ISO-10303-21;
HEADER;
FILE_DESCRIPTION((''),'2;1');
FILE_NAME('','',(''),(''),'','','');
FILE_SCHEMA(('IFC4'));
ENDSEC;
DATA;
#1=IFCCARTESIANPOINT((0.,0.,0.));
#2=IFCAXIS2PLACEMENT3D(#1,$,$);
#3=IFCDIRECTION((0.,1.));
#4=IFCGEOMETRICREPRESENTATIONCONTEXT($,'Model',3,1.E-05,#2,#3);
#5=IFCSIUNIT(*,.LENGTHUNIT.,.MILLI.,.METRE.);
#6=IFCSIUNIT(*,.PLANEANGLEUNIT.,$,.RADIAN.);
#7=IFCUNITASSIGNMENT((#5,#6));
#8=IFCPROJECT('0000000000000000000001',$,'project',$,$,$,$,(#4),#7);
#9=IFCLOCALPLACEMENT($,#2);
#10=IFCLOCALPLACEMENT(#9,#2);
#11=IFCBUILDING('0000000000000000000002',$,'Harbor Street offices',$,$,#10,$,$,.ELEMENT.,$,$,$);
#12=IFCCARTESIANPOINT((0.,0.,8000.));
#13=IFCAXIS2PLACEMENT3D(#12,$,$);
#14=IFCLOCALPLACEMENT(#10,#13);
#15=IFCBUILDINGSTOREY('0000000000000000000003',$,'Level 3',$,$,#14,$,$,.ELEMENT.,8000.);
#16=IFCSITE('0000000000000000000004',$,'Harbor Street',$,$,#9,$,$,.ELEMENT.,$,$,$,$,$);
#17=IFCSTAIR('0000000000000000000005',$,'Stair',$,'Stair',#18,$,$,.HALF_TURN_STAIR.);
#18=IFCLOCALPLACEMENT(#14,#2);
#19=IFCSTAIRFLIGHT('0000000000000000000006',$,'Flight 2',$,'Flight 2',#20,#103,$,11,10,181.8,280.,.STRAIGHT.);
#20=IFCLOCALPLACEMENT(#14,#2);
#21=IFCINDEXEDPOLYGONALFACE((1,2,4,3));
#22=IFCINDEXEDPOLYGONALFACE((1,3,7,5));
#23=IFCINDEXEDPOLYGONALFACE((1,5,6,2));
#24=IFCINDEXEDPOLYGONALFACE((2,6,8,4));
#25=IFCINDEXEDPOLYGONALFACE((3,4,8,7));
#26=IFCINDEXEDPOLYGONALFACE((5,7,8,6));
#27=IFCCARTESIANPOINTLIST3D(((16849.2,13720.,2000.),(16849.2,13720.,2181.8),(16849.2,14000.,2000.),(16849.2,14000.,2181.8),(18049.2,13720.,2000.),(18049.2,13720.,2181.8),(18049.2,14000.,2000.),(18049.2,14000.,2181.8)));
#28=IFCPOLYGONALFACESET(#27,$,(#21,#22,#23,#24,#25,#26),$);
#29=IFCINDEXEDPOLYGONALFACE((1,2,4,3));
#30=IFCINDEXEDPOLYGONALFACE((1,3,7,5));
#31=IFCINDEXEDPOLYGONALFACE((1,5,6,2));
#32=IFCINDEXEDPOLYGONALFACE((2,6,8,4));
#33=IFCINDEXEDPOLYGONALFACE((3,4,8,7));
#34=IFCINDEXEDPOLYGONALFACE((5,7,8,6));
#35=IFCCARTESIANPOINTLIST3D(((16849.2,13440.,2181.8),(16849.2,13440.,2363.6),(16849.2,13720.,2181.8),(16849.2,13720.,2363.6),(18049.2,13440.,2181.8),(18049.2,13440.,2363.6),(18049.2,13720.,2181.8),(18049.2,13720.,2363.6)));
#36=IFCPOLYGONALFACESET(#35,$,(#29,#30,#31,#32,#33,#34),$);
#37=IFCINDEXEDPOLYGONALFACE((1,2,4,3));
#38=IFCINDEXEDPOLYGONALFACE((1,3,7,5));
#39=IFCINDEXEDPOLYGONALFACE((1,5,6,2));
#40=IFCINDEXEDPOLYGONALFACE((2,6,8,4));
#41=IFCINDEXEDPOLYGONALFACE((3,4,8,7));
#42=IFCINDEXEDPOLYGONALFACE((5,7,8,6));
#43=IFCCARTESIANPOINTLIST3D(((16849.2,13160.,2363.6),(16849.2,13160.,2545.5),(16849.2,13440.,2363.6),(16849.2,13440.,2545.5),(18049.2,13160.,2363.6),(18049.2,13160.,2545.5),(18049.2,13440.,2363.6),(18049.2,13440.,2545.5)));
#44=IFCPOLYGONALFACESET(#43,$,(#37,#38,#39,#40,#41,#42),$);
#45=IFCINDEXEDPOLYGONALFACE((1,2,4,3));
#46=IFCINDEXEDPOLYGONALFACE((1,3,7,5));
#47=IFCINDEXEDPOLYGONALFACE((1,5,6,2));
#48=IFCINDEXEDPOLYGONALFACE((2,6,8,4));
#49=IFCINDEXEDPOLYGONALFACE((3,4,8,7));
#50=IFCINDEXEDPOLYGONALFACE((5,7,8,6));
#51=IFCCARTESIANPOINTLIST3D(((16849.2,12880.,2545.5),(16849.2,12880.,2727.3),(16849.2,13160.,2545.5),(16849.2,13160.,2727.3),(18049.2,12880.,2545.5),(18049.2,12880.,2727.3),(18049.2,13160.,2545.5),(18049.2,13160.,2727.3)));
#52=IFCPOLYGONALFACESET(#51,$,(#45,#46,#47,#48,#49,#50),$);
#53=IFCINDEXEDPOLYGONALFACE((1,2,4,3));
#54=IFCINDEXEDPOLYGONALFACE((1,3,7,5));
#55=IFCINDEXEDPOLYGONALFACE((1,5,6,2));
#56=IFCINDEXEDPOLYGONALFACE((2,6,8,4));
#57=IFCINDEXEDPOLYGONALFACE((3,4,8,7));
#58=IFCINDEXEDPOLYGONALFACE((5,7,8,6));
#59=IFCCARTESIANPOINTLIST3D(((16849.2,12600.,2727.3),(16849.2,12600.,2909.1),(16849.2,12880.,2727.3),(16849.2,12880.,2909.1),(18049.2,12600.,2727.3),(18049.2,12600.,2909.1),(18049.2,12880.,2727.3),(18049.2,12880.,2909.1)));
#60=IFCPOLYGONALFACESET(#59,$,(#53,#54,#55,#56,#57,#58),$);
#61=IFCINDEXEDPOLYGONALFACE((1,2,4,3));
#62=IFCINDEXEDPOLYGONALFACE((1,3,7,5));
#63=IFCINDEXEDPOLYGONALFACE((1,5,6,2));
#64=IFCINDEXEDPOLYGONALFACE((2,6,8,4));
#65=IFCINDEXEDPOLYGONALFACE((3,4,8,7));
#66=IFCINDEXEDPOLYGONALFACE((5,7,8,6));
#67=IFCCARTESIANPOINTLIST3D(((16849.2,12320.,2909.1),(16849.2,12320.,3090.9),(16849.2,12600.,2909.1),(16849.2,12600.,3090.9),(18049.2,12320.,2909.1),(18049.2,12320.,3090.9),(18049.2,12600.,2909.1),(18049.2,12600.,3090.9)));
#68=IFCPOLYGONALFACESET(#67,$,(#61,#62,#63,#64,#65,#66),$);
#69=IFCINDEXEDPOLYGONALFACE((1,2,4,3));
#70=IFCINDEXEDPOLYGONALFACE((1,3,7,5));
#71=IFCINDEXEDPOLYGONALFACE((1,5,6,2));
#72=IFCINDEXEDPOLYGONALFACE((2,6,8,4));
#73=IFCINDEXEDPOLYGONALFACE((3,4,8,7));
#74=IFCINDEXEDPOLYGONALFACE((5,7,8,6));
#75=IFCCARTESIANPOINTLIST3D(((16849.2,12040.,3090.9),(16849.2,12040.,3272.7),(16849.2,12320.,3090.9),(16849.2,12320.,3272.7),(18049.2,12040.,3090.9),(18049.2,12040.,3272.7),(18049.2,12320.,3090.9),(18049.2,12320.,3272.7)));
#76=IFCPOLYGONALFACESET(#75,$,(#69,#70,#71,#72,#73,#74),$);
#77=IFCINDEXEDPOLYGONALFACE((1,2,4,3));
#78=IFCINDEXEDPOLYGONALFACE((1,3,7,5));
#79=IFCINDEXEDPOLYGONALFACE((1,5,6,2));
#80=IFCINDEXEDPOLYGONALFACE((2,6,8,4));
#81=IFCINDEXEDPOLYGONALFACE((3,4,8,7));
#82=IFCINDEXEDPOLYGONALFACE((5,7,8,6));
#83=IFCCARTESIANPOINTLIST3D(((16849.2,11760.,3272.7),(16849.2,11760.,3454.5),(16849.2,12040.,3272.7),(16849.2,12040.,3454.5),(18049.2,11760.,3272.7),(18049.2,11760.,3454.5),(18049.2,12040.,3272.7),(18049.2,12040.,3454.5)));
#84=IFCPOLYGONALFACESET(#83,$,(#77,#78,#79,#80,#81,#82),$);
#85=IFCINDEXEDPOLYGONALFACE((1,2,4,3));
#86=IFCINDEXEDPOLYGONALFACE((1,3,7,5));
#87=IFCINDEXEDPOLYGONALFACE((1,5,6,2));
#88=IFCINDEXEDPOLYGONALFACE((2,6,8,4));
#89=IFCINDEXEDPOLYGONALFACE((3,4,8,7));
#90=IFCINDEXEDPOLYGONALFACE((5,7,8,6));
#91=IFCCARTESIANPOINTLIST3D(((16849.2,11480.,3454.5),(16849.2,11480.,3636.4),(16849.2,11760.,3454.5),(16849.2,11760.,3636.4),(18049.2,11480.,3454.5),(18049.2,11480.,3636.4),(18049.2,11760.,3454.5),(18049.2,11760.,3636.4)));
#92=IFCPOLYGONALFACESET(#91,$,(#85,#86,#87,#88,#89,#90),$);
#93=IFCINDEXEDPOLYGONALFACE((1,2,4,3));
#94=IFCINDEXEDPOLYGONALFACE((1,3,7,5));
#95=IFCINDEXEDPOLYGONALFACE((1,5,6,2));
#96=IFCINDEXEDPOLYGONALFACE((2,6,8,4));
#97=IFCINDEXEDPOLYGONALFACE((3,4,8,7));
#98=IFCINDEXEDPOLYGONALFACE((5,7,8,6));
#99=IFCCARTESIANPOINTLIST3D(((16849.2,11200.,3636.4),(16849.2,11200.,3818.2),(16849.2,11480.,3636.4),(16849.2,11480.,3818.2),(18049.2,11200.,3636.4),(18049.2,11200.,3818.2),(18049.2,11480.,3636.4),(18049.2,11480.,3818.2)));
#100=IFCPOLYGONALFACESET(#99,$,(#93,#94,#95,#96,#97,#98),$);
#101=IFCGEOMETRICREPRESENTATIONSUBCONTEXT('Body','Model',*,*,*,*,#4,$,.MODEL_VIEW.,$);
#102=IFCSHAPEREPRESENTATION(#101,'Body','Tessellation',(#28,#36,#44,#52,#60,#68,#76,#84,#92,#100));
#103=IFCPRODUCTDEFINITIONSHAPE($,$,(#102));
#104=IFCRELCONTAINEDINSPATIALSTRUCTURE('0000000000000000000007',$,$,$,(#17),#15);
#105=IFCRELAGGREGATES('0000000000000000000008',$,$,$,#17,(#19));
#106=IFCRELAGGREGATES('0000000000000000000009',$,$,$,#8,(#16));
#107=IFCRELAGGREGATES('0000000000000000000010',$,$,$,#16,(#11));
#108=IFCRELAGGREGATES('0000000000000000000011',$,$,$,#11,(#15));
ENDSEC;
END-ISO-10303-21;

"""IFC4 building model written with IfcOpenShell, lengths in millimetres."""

from ifc_helpers import new_model, si_unit, direction, frame, origin, origin_with_axes, place, context, subcontext, project, spatial, polyline, outline, extrude, element, aggregate, save


model = new_model("IFC4")

# Units and contexts
model_context = context("Model", 3, precision=1e-05, world=origin(), true_north=direction((0.0, 1.0)))
body_context = subcontext(model_context, "Body", "Model", "MODEL_VIEW")
ifc_project = project(units=[si_unit("LENGTHUNIT", "METRE", prefix="MILLI"), si_unit("PLANEANGLEUNIT", "RADIAN")], contexts=[model_context])

# Site, building, storey
site_placement = place(None, origin())
site = spatial("IfcSite", under=ifc_project, at=site_placement, Name="Harbor Street", CompositionType="ELEMENT")
building_placement = place(site_placement, origin())
building = spatial("IfcBuilding", under=site, at=building_placement, Name="Harbor Street offices", CompositionType="ELEMENT")
storey_placement = place(building_placement, frame((0.0, 0.0, 8000.0)))
storey = spatial("IfcBuildingStorey", under=building, at=storey_placement, Name="Level 3", CompositionType="ELEMENT", Elevation=8000.0)

# Stair
stair_placement = place(storey_placement, origin_with_axes())
stair = element("IfcStair", 1, at=stair_placement, inside=storey, Name="Stair", ObjectType="Stair", PredefinedType="HALF_TURN_STAIR")

# Stair flight
stair_flight_1_placement = place(storey_placement, origin_with_axes())
stair_flight_1 = element("IfcStairFlight", 2, at=stair_flight_1_placement, Name="Flight 2", ObjectType="Flight 2", NumberOfRisers=11, NumberOfTreads=10, PredefinedType="STRAIGHT", RiserHeight=181.8, TreadLength=280.0, context=body_context, shape_type="SweptSolid", body=[
    extrude(outline(polyline([(18049.2, 13720.0), (18049.2, 14000.0), (16849.2, 14000.0), (16849.2, 13720.0), (18049.2, 13720.0)])), frame((0.0, 0.0, 2000.0)), (0.0, 0.0, 1.0), 181.8),
    extrude(outline(polyline([(18049.2, 13440.0), (18049.2, 13720.0), (16849.2, 13720.0), (16849.2, 13440.0), (18049.2, 13440.0)])), frame((0.0, 0.0, 2181.8)), (0.0, 0.0, 1.0), 181.8),
    extrude(outline(polyline([(18049.2, 13160.0), (18049.2, 13440.0), (16849.2, 13440.0), (16849.2, 13160.0), (18049.2, 13160.0)])), frame((0.0, 0.0, 2363.6)), (0.0, 0.0, 1.0), 181.8),
    extrude(outline(polyline([(18049.2, 12880.0), (18049.2, 13160.0), (16849.2, 13160.0), (16849.2, 12880.0), (18049.2, 12880.0)])), frame((0.0, 0.0, 2545.5)), (0.0, 0.0, 1.0), 181.8),
    extrude(outline(polyline([(18049.2, 12600.0), (18049.2, 12880.0), (16849.2, 12880.0), (16849.2, 12600.0), (18049.2, 12600.0)])), frame((0.0, 0.0, 2727.3)), (0.0, 0.0, 1.0), 181.8),
    extrude(outline(polyline([(18049.2, 12320.0), (18049.2, 12600.0), (16849.2, 12600.0), (16849.2, 12320.0), (18049.2, 12320.0)])), frame((0.0, 0.0, 2909.1)), (0.0, 0.0, 1.0), 181.8),
    extrude(outline(polyline([(18049.2, 12040.0), (18049.2, 12320.0), (16849.2, 12320.0), (16849.2, 12040.0), (18049.2, 12040.0)])), frame((0.0, 0.0, 3090.9)), (0.0, 0.0, 1.0), 181.8),
    extrude(outline(polyline([(18049.2, 11760.0), (18049.2, 12040.0), (16849.2, 12040.0), (16849.2, 11760.0), (18049.2, 11760.0)])), frame((0.0, 0.0, 3272.7)), (0.0, 0.0, 1.0), 181.8),
    extrude(outline(polyline([(18049.2, 11480.0), (18049.2, 11760.0), (16849.2, 11760.0), (16849.2, 11480.0), (18049.2, 11480.0)])), frame((0.0, 0.0, 3454.5)), (0.0, 0.0, 1.0), 181.8),
    extrude(outline(polyline([(18049.2, 11200.0), (18049.2, 11480.0), (16849.2, 11480.0), (16849.2, 11200.0), (18049.2, 11200.0)])), frame((0.0, 0.0, 3636.4)), (0.0, 0.0, 1.0), 181.8),
])

aggregate(stair, [stair_flight_1])

save(model, "model.ifc")
